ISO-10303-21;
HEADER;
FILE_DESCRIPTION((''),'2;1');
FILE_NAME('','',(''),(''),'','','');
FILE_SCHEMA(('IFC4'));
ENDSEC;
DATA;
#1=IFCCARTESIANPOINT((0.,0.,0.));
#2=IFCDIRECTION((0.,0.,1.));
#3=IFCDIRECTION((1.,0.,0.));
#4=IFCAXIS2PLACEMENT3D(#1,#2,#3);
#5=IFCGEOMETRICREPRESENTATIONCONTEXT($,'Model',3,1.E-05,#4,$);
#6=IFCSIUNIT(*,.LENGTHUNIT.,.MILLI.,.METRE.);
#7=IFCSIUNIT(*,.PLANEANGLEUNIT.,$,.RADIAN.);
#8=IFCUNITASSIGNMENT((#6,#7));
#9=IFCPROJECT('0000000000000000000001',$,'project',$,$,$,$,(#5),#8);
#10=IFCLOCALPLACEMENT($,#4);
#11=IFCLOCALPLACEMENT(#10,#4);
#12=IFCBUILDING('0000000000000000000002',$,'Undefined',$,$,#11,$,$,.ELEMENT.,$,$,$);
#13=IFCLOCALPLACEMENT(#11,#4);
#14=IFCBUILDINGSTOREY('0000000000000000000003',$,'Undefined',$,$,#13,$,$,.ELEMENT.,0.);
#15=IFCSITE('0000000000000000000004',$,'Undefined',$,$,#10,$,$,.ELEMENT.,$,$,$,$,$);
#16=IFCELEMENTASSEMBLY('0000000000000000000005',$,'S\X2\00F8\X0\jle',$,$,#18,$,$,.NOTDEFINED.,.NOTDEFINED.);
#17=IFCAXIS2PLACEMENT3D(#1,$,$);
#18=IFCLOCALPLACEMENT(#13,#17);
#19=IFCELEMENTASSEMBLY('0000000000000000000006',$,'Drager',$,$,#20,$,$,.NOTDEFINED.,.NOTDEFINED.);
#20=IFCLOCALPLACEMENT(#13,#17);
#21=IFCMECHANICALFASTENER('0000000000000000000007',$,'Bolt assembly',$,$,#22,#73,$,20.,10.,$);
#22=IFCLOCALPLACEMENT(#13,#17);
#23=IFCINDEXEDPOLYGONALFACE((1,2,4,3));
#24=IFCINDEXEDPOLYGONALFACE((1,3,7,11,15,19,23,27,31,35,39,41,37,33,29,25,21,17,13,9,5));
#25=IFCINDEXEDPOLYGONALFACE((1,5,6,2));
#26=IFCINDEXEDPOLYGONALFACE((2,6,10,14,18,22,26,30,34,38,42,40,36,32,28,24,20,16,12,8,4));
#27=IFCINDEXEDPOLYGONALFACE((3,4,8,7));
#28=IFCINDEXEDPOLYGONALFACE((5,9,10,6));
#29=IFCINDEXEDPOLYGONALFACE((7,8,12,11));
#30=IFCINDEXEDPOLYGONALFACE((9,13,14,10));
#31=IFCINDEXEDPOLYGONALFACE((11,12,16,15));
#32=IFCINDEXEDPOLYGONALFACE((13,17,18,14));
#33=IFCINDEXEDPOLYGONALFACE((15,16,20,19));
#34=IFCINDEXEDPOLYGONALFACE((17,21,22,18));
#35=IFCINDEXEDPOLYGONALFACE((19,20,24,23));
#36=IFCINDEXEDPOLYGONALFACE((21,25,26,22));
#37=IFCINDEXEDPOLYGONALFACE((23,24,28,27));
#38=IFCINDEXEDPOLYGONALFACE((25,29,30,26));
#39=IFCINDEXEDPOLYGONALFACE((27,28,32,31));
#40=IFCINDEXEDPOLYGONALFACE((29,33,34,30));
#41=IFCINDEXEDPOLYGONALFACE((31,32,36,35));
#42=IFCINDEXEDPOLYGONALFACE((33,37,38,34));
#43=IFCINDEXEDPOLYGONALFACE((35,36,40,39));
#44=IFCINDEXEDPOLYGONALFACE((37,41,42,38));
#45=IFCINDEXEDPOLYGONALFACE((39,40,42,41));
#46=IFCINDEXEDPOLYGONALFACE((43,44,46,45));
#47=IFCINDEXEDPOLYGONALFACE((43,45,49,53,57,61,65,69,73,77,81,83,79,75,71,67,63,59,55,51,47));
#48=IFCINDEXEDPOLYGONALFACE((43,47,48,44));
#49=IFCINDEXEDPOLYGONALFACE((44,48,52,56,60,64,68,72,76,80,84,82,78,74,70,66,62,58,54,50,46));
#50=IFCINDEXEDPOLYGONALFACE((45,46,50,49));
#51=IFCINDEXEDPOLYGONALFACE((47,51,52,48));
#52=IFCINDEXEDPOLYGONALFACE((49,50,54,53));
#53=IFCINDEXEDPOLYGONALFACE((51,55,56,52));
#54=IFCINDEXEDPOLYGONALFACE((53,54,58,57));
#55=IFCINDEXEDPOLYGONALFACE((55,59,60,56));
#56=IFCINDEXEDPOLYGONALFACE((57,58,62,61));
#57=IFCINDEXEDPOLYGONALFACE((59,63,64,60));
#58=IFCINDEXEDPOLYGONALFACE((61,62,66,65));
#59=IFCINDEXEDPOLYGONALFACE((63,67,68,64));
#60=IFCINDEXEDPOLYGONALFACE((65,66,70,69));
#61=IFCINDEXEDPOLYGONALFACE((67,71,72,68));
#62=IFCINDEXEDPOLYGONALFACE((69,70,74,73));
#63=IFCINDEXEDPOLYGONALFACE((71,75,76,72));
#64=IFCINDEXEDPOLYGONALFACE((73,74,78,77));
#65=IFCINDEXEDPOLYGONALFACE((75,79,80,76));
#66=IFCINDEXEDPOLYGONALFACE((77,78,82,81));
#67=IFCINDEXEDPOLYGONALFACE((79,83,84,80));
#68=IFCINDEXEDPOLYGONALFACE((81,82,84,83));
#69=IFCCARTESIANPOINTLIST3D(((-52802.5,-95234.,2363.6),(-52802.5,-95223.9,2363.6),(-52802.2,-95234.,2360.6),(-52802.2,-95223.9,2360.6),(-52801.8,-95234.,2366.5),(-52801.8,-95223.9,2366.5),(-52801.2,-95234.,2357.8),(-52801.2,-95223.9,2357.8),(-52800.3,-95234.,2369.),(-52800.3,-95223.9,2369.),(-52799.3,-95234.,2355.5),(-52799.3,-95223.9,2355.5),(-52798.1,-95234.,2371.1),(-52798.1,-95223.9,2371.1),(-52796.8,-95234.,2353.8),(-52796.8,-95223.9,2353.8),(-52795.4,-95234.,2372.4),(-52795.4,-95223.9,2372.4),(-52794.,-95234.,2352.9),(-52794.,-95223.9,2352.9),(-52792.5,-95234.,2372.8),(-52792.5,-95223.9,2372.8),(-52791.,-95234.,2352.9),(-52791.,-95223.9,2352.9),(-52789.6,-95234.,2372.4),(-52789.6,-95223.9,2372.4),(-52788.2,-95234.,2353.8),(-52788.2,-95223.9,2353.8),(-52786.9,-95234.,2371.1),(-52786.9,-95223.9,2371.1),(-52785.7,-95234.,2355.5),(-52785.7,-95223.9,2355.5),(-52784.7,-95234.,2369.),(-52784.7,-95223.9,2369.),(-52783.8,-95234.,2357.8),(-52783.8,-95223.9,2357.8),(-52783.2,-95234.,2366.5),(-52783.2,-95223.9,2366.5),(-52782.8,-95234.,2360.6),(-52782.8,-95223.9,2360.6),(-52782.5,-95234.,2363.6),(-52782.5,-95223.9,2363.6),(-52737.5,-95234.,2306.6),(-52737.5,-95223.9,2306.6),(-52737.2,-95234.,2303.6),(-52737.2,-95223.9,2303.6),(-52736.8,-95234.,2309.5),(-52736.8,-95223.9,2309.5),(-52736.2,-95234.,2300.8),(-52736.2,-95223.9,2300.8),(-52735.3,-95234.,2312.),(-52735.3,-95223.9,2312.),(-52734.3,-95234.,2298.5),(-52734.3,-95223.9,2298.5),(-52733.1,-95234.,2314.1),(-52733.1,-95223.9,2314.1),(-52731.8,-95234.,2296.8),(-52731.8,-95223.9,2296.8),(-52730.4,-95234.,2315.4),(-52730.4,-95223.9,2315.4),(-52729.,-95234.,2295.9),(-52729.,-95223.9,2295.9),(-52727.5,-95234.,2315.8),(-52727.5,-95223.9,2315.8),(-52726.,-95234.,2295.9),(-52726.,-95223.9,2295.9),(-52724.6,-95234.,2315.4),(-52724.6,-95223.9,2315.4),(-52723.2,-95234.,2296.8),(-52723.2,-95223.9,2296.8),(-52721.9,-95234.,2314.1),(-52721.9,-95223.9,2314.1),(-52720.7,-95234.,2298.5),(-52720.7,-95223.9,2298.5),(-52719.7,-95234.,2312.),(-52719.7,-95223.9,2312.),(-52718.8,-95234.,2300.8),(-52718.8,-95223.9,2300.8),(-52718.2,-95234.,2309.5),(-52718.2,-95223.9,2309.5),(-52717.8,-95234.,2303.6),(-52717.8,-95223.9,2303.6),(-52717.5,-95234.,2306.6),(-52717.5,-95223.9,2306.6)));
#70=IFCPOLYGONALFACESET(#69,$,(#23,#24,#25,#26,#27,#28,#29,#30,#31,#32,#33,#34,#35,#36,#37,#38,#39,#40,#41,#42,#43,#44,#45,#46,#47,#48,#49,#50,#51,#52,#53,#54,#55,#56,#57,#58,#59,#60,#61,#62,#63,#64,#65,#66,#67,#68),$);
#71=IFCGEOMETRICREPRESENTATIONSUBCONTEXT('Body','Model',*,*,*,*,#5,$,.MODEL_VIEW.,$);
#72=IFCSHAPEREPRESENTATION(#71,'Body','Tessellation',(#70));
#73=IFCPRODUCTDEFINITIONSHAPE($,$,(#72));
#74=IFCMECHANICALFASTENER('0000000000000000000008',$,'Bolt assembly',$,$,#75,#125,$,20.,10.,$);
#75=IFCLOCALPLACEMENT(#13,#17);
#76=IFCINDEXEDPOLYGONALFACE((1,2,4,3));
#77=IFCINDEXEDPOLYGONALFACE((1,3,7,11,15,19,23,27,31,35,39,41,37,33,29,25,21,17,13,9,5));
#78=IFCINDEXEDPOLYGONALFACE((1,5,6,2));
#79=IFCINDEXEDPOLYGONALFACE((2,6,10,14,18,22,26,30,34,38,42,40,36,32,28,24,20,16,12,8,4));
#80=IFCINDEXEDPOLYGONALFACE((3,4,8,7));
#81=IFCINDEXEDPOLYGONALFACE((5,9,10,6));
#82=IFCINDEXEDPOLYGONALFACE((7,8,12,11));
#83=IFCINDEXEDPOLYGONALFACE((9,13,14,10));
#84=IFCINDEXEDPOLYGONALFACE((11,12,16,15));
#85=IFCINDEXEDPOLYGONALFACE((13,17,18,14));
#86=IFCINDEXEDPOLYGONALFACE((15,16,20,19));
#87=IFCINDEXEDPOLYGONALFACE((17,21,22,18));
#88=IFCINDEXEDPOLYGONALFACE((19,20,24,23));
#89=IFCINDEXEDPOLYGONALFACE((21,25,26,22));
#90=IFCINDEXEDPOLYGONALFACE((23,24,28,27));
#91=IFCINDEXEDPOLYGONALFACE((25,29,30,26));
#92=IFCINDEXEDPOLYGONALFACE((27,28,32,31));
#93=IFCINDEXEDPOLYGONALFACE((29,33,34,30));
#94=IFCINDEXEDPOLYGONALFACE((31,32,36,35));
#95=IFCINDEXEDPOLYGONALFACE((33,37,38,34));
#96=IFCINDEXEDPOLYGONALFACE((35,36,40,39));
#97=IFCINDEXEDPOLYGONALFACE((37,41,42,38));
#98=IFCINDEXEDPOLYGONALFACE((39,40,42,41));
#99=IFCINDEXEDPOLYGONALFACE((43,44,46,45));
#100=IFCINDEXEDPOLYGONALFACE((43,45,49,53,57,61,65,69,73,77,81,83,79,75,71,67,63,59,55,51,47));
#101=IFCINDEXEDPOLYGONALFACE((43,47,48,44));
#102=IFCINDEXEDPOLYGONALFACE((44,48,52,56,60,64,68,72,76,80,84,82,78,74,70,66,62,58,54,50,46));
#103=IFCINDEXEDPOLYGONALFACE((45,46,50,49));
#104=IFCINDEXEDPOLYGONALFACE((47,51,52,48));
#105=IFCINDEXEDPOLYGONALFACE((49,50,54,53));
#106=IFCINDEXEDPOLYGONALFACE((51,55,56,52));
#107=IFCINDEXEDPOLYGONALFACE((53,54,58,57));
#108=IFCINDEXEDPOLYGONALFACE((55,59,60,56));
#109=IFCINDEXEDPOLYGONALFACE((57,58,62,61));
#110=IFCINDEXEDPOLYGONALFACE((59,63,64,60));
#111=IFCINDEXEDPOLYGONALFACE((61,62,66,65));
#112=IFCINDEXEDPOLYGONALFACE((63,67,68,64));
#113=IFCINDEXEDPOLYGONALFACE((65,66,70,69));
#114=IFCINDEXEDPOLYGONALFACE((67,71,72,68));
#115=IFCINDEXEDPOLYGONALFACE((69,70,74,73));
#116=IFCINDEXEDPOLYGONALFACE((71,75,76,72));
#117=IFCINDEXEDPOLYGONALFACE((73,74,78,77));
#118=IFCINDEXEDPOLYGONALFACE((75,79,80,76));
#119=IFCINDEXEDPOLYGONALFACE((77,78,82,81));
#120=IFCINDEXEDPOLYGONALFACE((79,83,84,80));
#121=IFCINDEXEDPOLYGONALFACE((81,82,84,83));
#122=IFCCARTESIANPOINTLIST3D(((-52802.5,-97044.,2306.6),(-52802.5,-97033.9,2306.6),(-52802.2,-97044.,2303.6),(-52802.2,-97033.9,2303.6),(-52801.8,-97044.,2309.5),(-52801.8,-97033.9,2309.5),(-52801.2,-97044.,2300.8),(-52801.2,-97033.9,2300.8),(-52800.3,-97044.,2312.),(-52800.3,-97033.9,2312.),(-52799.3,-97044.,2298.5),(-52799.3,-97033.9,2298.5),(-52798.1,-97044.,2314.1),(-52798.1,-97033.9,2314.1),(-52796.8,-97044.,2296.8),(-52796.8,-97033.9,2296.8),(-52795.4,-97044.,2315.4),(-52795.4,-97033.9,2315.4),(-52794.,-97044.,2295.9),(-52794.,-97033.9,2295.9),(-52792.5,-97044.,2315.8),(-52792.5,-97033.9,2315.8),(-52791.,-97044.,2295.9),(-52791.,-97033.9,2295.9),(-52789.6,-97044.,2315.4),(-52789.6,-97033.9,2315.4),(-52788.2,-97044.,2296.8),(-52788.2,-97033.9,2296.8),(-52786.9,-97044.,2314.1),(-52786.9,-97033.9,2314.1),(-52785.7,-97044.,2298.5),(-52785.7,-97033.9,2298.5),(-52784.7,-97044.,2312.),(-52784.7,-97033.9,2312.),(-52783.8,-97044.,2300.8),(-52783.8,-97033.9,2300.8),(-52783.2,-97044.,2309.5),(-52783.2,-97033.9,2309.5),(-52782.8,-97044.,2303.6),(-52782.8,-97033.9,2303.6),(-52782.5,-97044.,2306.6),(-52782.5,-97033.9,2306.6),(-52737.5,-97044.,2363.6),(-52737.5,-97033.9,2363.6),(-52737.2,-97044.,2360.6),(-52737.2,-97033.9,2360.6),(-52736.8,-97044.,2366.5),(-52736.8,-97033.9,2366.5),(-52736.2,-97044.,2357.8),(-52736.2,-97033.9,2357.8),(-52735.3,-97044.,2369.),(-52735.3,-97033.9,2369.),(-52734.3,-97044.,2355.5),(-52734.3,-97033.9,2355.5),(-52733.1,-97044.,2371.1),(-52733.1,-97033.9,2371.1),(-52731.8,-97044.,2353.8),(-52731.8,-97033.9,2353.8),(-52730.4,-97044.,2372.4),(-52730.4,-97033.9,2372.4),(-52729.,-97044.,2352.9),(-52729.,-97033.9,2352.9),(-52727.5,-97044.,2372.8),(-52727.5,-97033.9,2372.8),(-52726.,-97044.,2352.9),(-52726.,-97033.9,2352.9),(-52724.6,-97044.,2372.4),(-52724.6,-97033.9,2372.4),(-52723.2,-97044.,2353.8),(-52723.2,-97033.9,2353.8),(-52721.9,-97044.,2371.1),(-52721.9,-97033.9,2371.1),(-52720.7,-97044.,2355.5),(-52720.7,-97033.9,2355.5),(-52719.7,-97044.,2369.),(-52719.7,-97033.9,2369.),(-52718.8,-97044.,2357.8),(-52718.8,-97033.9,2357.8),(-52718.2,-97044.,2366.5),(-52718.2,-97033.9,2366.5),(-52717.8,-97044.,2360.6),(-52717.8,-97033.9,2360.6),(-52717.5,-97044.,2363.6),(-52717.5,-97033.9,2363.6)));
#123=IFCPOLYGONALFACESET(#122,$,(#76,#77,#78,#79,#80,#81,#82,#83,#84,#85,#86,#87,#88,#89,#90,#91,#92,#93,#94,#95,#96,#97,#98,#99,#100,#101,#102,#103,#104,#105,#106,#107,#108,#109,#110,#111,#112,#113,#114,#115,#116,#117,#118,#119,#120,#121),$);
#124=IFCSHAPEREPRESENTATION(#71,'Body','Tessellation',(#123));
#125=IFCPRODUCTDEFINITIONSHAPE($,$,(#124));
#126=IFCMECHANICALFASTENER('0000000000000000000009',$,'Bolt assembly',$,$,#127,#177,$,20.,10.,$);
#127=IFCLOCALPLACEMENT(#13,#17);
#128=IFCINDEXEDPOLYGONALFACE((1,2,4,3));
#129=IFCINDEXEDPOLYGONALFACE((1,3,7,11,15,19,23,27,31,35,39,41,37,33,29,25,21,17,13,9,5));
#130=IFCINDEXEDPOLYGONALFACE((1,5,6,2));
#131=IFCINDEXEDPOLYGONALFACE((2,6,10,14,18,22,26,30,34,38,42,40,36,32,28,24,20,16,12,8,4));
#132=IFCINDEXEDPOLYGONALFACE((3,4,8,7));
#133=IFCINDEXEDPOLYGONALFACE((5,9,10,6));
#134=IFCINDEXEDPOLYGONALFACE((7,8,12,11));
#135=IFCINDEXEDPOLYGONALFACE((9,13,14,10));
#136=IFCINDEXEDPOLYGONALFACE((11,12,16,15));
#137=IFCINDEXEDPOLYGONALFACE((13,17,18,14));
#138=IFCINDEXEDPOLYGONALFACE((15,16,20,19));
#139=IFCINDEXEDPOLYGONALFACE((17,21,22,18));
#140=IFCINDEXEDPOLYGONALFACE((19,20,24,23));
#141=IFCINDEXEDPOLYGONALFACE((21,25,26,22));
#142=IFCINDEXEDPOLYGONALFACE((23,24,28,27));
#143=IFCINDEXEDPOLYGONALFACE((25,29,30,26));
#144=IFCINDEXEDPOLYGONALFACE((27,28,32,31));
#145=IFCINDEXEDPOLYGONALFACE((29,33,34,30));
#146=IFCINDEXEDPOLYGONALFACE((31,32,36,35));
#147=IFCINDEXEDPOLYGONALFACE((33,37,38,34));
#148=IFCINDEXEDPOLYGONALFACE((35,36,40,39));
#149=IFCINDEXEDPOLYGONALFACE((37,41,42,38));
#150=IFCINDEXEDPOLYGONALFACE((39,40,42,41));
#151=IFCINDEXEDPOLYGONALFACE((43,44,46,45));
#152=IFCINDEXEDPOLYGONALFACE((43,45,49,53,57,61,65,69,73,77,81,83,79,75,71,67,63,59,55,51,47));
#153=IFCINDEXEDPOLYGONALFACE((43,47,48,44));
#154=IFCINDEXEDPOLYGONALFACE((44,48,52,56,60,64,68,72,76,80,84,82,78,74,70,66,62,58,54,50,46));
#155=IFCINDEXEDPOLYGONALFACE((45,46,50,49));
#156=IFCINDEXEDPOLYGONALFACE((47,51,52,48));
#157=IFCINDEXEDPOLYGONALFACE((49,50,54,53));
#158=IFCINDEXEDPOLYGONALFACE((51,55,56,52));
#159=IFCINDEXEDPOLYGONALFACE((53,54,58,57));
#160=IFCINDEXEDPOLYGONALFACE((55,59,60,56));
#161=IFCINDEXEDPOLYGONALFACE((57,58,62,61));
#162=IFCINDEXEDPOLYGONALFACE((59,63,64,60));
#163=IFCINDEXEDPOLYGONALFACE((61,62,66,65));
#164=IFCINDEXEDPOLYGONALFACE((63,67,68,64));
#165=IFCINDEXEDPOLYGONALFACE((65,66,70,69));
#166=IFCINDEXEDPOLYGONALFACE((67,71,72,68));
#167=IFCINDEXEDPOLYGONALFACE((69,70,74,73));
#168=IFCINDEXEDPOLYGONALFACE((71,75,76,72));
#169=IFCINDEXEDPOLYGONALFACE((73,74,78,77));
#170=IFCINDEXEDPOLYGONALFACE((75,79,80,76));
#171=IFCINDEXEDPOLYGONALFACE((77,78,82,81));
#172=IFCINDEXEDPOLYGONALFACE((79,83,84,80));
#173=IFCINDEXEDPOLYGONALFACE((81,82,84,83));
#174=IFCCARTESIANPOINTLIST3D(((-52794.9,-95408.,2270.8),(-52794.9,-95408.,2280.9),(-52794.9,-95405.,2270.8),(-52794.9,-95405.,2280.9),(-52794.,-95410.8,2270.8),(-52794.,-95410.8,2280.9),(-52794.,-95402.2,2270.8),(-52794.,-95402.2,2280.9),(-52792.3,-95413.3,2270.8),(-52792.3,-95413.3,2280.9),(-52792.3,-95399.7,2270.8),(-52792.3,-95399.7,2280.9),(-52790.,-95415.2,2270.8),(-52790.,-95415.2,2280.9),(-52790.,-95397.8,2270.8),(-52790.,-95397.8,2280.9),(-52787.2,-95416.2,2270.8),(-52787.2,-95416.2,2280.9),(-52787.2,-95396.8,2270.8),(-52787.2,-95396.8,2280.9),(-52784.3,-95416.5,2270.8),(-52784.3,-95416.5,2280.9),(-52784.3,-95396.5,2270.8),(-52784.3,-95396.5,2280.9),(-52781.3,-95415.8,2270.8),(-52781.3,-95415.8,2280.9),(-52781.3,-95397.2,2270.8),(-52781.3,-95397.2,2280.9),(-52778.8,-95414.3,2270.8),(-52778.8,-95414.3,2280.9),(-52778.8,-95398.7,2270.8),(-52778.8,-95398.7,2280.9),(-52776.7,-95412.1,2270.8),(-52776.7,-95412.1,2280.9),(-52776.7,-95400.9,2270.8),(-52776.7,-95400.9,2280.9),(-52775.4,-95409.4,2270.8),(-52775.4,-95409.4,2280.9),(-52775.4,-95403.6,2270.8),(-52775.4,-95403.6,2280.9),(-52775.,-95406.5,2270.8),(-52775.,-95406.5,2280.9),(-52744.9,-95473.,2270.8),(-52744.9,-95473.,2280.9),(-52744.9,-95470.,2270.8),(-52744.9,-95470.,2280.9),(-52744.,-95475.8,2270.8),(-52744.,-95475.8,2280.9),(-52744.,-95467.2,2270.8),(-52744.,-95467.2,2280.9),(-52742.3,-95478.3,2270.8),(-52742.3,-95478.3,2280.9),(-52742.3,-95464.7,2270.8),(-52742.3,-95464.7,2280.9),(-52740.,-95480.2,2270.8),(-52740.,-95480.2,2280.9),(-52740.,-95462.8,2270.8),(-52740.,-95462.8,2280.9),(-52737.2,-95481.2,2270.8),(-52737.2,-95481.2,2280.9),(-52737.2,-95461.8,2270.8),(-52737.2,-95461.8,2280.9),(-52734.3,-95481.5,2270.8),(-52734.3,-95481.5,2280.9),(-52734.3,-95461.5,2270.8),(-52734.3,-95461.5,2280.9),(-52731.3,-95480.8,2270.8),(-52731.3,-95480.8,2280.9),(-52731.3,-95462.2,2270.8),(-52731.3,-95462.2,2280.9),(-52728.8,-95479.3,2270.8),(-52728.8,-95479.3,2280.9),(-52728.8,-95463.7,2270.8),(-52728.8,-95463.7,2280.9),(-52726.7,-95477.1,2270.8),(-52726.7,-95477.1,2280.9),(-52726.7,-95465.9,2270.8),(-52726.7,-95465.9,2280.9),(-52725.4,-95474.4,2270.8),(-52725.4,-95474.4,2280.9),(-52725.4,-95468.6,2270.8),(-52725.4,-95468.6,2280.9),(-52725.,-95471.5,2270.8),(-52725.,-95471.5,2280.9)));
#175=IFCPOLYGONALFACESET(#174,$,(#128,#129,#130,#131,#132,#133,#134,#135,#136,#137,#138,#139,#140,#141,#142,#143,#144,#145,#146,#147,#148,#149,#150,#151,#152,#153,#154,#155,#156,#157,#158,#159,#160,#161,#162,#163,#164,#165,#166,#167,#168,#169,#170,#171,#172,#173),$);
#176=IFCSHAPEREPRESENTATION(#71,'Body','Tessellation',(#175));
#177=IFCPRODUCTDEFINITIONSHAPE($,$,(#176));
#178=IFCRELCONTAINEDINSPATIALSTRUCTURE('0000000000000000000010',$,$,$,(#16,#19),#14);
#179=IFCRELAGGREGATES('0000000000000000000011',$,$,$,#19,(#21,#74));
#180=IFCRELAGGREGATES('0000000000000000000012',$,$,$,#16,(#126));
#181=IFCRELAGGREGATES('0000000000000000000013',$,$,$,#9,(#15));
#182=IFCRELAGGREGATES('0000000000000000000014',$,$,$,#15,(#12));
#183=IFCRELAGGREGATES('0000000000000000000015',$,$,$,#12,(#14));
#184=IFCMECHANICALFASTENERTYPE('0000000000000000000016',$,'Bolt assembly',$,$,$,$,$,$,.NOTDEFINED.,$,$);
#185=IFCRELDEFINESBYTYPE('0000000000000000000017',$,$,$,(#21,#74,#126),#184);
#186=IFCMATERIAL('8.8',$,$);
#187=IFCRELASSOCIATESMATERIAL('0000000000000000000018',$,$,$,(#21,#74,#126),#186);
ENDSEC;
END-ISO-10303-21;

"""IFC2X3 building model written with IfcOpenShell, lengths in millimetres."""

from ifc_helpers import new_model, si_unit, frame, origin_with_axes, origin_2d_with_axis, place, context, subcontext, project, spatial, circle, extrude, source, transform, mapped, material, type_object, element, aggregate, save


model = new_model("IFC2X3")

# Units and contexts
model_context = context("Model", 3, precision=1e-05, world=origin_with_axes())
body_context = subcontext(model_context, "Body", "Model", "MODEL_VIEW")
ifc_project = project(units=[si_unit("LENGTHUNIT", "METRE", prefix="MILLI"), si_unit("PLANEANGLEUNIT", "RADIAN")], contexts=[model_context])

# Site, building, storey
site_placement = place(None, origin_with_axes())
site = spatial("IfcSite", under=ifc_project, at=site_placement, Name="Undefined", CompositionType="ELEMENT")
building_placement = place(site_placement, origin_with_axes())
building = spatial("IfcBuilding", under=site, at=building_placement, Name="Undefined", CompositionType="ELEMENT")
storey_placement = place(building_placement, origin_with_axes())
storey = spatial("IfcBuildingStorey", under=building, at=storey_placement, Name="Undefined", CompositionType="ELEMENT", Elevation=0.0)

# Element assembly
assembly_1_placement = place(storey_placement, origin_with_axes())
assembly_1 = element("IfcElementAssembly", 1, at=assembly_1_placement, inside=storey, Name="Søjle", AssemblyPlace="NOTDEFINED", PredefinedType="NOTDEFINED")

# Element assembly
assembly_2_placement = place(storey_placement, origin_with_axes())
assembly_2 = element("IfcElementAssembly", 2, at=assembly_2_placement, inside=storey, Name="Drager", AssemblyPlace="NOTDEFINED", PredefinedType="NOTDEFINED")

# Mechanical fasteners
ifc_material_1 = material(Name="8.8")
mechanical_fastener_type = type_object("IfcMechanicalFastenerType", Name="Bolt assembly")
shared_shape_1 = source(origin_with_axes(), body_context, "Body", "SweptSolid", [
    extrude(circle(Radius=10.0, at=origin_2d_with_axis()), frame((0.0, 0.0, 0.0), z_axis=(0.0, 1.0, 0.0), x_axis=(1.0, 0.0, 0.0)), (0.0, 0.0, 1.0), 10.1),
])
mechanical_fastener_1_placement = place(assembly_2_placement, frame((-52760.0, -95234.0, 2305.8), z_axis=(-1.0, 0.0, 0.0), x_axis=(0.0, 0.0, 1.0)))
mechanical_fastener_1 = element("IfcMechanicalFastener", 3, at=mechanical_fastener_1_placement, type_object=mechanical_fastener_type, material=ifc_material_1, Name="Bolt assembly", NominalDiameter=20.0, NominalLength=10.0, context=body_context, shape_type="MappedRepresentation", body=[
    mapped(shared_shape_1, transform((0.0, 0.0, -32.5))),
    mapped(shared_shape_1, transform((57.0, 0.0, 32.5))),
])
mechanical_fastener_2_placement = place(assembly_2_placement, frame((-52760.0, -97044.0, 2305.8), z_axis=(-1.0, 0.0, 0.0), x_axis=(0.0, 0.0, 1.0)))
mechanical_fastener_2 = element("IfcMechanicalFastener", 4, at=mechanical_fastener_2_placement, type_object=mechanical_fastener_type, material=ifc_material_1, Name="Bolt assembly", NominalDiameter=20.0, NominalLength=10.0, context=body_context, shape_type="MappedRepresentation", body=[
    mapped(shared_shape_1, transform((0.0, 0.0, 32.5))),
    mapped(shared_shape_1, transform((57.0, 0.0, -32.5))),
])
aggregate(assembly_2, [mechanical_fastener_1, mechanical_fastener_2])
mechanical_fastener_3_placement = place(assembly_1_placement, frame((-52785.0, -95439.0, 2270.8), z_axis=(0.0, -1.0, 0.0), x_axis=(1.0, 0.0, 0.0)))
mechanical_fastener_3 = element("IfcMechanicalFastener", 5, at=mechanical_fastener_3_placement, type_object=mechanical_fastener_type, material=ifc_material_1, Name="Bolt assembly", NominalDiameter=20.0, NominalLength=10.0, context=body_context, shape_type="MappedRepresentation", body=[
    mapped(shared_shape_1, transform((0.0, 0.0, -32.5))),
    mapped(shared_shape_1, transform((50.0, 0.0, 32.5))),
])

aggregate(assembly_1, [mechanical_fastener_3])

save(model, "model.ifc")
